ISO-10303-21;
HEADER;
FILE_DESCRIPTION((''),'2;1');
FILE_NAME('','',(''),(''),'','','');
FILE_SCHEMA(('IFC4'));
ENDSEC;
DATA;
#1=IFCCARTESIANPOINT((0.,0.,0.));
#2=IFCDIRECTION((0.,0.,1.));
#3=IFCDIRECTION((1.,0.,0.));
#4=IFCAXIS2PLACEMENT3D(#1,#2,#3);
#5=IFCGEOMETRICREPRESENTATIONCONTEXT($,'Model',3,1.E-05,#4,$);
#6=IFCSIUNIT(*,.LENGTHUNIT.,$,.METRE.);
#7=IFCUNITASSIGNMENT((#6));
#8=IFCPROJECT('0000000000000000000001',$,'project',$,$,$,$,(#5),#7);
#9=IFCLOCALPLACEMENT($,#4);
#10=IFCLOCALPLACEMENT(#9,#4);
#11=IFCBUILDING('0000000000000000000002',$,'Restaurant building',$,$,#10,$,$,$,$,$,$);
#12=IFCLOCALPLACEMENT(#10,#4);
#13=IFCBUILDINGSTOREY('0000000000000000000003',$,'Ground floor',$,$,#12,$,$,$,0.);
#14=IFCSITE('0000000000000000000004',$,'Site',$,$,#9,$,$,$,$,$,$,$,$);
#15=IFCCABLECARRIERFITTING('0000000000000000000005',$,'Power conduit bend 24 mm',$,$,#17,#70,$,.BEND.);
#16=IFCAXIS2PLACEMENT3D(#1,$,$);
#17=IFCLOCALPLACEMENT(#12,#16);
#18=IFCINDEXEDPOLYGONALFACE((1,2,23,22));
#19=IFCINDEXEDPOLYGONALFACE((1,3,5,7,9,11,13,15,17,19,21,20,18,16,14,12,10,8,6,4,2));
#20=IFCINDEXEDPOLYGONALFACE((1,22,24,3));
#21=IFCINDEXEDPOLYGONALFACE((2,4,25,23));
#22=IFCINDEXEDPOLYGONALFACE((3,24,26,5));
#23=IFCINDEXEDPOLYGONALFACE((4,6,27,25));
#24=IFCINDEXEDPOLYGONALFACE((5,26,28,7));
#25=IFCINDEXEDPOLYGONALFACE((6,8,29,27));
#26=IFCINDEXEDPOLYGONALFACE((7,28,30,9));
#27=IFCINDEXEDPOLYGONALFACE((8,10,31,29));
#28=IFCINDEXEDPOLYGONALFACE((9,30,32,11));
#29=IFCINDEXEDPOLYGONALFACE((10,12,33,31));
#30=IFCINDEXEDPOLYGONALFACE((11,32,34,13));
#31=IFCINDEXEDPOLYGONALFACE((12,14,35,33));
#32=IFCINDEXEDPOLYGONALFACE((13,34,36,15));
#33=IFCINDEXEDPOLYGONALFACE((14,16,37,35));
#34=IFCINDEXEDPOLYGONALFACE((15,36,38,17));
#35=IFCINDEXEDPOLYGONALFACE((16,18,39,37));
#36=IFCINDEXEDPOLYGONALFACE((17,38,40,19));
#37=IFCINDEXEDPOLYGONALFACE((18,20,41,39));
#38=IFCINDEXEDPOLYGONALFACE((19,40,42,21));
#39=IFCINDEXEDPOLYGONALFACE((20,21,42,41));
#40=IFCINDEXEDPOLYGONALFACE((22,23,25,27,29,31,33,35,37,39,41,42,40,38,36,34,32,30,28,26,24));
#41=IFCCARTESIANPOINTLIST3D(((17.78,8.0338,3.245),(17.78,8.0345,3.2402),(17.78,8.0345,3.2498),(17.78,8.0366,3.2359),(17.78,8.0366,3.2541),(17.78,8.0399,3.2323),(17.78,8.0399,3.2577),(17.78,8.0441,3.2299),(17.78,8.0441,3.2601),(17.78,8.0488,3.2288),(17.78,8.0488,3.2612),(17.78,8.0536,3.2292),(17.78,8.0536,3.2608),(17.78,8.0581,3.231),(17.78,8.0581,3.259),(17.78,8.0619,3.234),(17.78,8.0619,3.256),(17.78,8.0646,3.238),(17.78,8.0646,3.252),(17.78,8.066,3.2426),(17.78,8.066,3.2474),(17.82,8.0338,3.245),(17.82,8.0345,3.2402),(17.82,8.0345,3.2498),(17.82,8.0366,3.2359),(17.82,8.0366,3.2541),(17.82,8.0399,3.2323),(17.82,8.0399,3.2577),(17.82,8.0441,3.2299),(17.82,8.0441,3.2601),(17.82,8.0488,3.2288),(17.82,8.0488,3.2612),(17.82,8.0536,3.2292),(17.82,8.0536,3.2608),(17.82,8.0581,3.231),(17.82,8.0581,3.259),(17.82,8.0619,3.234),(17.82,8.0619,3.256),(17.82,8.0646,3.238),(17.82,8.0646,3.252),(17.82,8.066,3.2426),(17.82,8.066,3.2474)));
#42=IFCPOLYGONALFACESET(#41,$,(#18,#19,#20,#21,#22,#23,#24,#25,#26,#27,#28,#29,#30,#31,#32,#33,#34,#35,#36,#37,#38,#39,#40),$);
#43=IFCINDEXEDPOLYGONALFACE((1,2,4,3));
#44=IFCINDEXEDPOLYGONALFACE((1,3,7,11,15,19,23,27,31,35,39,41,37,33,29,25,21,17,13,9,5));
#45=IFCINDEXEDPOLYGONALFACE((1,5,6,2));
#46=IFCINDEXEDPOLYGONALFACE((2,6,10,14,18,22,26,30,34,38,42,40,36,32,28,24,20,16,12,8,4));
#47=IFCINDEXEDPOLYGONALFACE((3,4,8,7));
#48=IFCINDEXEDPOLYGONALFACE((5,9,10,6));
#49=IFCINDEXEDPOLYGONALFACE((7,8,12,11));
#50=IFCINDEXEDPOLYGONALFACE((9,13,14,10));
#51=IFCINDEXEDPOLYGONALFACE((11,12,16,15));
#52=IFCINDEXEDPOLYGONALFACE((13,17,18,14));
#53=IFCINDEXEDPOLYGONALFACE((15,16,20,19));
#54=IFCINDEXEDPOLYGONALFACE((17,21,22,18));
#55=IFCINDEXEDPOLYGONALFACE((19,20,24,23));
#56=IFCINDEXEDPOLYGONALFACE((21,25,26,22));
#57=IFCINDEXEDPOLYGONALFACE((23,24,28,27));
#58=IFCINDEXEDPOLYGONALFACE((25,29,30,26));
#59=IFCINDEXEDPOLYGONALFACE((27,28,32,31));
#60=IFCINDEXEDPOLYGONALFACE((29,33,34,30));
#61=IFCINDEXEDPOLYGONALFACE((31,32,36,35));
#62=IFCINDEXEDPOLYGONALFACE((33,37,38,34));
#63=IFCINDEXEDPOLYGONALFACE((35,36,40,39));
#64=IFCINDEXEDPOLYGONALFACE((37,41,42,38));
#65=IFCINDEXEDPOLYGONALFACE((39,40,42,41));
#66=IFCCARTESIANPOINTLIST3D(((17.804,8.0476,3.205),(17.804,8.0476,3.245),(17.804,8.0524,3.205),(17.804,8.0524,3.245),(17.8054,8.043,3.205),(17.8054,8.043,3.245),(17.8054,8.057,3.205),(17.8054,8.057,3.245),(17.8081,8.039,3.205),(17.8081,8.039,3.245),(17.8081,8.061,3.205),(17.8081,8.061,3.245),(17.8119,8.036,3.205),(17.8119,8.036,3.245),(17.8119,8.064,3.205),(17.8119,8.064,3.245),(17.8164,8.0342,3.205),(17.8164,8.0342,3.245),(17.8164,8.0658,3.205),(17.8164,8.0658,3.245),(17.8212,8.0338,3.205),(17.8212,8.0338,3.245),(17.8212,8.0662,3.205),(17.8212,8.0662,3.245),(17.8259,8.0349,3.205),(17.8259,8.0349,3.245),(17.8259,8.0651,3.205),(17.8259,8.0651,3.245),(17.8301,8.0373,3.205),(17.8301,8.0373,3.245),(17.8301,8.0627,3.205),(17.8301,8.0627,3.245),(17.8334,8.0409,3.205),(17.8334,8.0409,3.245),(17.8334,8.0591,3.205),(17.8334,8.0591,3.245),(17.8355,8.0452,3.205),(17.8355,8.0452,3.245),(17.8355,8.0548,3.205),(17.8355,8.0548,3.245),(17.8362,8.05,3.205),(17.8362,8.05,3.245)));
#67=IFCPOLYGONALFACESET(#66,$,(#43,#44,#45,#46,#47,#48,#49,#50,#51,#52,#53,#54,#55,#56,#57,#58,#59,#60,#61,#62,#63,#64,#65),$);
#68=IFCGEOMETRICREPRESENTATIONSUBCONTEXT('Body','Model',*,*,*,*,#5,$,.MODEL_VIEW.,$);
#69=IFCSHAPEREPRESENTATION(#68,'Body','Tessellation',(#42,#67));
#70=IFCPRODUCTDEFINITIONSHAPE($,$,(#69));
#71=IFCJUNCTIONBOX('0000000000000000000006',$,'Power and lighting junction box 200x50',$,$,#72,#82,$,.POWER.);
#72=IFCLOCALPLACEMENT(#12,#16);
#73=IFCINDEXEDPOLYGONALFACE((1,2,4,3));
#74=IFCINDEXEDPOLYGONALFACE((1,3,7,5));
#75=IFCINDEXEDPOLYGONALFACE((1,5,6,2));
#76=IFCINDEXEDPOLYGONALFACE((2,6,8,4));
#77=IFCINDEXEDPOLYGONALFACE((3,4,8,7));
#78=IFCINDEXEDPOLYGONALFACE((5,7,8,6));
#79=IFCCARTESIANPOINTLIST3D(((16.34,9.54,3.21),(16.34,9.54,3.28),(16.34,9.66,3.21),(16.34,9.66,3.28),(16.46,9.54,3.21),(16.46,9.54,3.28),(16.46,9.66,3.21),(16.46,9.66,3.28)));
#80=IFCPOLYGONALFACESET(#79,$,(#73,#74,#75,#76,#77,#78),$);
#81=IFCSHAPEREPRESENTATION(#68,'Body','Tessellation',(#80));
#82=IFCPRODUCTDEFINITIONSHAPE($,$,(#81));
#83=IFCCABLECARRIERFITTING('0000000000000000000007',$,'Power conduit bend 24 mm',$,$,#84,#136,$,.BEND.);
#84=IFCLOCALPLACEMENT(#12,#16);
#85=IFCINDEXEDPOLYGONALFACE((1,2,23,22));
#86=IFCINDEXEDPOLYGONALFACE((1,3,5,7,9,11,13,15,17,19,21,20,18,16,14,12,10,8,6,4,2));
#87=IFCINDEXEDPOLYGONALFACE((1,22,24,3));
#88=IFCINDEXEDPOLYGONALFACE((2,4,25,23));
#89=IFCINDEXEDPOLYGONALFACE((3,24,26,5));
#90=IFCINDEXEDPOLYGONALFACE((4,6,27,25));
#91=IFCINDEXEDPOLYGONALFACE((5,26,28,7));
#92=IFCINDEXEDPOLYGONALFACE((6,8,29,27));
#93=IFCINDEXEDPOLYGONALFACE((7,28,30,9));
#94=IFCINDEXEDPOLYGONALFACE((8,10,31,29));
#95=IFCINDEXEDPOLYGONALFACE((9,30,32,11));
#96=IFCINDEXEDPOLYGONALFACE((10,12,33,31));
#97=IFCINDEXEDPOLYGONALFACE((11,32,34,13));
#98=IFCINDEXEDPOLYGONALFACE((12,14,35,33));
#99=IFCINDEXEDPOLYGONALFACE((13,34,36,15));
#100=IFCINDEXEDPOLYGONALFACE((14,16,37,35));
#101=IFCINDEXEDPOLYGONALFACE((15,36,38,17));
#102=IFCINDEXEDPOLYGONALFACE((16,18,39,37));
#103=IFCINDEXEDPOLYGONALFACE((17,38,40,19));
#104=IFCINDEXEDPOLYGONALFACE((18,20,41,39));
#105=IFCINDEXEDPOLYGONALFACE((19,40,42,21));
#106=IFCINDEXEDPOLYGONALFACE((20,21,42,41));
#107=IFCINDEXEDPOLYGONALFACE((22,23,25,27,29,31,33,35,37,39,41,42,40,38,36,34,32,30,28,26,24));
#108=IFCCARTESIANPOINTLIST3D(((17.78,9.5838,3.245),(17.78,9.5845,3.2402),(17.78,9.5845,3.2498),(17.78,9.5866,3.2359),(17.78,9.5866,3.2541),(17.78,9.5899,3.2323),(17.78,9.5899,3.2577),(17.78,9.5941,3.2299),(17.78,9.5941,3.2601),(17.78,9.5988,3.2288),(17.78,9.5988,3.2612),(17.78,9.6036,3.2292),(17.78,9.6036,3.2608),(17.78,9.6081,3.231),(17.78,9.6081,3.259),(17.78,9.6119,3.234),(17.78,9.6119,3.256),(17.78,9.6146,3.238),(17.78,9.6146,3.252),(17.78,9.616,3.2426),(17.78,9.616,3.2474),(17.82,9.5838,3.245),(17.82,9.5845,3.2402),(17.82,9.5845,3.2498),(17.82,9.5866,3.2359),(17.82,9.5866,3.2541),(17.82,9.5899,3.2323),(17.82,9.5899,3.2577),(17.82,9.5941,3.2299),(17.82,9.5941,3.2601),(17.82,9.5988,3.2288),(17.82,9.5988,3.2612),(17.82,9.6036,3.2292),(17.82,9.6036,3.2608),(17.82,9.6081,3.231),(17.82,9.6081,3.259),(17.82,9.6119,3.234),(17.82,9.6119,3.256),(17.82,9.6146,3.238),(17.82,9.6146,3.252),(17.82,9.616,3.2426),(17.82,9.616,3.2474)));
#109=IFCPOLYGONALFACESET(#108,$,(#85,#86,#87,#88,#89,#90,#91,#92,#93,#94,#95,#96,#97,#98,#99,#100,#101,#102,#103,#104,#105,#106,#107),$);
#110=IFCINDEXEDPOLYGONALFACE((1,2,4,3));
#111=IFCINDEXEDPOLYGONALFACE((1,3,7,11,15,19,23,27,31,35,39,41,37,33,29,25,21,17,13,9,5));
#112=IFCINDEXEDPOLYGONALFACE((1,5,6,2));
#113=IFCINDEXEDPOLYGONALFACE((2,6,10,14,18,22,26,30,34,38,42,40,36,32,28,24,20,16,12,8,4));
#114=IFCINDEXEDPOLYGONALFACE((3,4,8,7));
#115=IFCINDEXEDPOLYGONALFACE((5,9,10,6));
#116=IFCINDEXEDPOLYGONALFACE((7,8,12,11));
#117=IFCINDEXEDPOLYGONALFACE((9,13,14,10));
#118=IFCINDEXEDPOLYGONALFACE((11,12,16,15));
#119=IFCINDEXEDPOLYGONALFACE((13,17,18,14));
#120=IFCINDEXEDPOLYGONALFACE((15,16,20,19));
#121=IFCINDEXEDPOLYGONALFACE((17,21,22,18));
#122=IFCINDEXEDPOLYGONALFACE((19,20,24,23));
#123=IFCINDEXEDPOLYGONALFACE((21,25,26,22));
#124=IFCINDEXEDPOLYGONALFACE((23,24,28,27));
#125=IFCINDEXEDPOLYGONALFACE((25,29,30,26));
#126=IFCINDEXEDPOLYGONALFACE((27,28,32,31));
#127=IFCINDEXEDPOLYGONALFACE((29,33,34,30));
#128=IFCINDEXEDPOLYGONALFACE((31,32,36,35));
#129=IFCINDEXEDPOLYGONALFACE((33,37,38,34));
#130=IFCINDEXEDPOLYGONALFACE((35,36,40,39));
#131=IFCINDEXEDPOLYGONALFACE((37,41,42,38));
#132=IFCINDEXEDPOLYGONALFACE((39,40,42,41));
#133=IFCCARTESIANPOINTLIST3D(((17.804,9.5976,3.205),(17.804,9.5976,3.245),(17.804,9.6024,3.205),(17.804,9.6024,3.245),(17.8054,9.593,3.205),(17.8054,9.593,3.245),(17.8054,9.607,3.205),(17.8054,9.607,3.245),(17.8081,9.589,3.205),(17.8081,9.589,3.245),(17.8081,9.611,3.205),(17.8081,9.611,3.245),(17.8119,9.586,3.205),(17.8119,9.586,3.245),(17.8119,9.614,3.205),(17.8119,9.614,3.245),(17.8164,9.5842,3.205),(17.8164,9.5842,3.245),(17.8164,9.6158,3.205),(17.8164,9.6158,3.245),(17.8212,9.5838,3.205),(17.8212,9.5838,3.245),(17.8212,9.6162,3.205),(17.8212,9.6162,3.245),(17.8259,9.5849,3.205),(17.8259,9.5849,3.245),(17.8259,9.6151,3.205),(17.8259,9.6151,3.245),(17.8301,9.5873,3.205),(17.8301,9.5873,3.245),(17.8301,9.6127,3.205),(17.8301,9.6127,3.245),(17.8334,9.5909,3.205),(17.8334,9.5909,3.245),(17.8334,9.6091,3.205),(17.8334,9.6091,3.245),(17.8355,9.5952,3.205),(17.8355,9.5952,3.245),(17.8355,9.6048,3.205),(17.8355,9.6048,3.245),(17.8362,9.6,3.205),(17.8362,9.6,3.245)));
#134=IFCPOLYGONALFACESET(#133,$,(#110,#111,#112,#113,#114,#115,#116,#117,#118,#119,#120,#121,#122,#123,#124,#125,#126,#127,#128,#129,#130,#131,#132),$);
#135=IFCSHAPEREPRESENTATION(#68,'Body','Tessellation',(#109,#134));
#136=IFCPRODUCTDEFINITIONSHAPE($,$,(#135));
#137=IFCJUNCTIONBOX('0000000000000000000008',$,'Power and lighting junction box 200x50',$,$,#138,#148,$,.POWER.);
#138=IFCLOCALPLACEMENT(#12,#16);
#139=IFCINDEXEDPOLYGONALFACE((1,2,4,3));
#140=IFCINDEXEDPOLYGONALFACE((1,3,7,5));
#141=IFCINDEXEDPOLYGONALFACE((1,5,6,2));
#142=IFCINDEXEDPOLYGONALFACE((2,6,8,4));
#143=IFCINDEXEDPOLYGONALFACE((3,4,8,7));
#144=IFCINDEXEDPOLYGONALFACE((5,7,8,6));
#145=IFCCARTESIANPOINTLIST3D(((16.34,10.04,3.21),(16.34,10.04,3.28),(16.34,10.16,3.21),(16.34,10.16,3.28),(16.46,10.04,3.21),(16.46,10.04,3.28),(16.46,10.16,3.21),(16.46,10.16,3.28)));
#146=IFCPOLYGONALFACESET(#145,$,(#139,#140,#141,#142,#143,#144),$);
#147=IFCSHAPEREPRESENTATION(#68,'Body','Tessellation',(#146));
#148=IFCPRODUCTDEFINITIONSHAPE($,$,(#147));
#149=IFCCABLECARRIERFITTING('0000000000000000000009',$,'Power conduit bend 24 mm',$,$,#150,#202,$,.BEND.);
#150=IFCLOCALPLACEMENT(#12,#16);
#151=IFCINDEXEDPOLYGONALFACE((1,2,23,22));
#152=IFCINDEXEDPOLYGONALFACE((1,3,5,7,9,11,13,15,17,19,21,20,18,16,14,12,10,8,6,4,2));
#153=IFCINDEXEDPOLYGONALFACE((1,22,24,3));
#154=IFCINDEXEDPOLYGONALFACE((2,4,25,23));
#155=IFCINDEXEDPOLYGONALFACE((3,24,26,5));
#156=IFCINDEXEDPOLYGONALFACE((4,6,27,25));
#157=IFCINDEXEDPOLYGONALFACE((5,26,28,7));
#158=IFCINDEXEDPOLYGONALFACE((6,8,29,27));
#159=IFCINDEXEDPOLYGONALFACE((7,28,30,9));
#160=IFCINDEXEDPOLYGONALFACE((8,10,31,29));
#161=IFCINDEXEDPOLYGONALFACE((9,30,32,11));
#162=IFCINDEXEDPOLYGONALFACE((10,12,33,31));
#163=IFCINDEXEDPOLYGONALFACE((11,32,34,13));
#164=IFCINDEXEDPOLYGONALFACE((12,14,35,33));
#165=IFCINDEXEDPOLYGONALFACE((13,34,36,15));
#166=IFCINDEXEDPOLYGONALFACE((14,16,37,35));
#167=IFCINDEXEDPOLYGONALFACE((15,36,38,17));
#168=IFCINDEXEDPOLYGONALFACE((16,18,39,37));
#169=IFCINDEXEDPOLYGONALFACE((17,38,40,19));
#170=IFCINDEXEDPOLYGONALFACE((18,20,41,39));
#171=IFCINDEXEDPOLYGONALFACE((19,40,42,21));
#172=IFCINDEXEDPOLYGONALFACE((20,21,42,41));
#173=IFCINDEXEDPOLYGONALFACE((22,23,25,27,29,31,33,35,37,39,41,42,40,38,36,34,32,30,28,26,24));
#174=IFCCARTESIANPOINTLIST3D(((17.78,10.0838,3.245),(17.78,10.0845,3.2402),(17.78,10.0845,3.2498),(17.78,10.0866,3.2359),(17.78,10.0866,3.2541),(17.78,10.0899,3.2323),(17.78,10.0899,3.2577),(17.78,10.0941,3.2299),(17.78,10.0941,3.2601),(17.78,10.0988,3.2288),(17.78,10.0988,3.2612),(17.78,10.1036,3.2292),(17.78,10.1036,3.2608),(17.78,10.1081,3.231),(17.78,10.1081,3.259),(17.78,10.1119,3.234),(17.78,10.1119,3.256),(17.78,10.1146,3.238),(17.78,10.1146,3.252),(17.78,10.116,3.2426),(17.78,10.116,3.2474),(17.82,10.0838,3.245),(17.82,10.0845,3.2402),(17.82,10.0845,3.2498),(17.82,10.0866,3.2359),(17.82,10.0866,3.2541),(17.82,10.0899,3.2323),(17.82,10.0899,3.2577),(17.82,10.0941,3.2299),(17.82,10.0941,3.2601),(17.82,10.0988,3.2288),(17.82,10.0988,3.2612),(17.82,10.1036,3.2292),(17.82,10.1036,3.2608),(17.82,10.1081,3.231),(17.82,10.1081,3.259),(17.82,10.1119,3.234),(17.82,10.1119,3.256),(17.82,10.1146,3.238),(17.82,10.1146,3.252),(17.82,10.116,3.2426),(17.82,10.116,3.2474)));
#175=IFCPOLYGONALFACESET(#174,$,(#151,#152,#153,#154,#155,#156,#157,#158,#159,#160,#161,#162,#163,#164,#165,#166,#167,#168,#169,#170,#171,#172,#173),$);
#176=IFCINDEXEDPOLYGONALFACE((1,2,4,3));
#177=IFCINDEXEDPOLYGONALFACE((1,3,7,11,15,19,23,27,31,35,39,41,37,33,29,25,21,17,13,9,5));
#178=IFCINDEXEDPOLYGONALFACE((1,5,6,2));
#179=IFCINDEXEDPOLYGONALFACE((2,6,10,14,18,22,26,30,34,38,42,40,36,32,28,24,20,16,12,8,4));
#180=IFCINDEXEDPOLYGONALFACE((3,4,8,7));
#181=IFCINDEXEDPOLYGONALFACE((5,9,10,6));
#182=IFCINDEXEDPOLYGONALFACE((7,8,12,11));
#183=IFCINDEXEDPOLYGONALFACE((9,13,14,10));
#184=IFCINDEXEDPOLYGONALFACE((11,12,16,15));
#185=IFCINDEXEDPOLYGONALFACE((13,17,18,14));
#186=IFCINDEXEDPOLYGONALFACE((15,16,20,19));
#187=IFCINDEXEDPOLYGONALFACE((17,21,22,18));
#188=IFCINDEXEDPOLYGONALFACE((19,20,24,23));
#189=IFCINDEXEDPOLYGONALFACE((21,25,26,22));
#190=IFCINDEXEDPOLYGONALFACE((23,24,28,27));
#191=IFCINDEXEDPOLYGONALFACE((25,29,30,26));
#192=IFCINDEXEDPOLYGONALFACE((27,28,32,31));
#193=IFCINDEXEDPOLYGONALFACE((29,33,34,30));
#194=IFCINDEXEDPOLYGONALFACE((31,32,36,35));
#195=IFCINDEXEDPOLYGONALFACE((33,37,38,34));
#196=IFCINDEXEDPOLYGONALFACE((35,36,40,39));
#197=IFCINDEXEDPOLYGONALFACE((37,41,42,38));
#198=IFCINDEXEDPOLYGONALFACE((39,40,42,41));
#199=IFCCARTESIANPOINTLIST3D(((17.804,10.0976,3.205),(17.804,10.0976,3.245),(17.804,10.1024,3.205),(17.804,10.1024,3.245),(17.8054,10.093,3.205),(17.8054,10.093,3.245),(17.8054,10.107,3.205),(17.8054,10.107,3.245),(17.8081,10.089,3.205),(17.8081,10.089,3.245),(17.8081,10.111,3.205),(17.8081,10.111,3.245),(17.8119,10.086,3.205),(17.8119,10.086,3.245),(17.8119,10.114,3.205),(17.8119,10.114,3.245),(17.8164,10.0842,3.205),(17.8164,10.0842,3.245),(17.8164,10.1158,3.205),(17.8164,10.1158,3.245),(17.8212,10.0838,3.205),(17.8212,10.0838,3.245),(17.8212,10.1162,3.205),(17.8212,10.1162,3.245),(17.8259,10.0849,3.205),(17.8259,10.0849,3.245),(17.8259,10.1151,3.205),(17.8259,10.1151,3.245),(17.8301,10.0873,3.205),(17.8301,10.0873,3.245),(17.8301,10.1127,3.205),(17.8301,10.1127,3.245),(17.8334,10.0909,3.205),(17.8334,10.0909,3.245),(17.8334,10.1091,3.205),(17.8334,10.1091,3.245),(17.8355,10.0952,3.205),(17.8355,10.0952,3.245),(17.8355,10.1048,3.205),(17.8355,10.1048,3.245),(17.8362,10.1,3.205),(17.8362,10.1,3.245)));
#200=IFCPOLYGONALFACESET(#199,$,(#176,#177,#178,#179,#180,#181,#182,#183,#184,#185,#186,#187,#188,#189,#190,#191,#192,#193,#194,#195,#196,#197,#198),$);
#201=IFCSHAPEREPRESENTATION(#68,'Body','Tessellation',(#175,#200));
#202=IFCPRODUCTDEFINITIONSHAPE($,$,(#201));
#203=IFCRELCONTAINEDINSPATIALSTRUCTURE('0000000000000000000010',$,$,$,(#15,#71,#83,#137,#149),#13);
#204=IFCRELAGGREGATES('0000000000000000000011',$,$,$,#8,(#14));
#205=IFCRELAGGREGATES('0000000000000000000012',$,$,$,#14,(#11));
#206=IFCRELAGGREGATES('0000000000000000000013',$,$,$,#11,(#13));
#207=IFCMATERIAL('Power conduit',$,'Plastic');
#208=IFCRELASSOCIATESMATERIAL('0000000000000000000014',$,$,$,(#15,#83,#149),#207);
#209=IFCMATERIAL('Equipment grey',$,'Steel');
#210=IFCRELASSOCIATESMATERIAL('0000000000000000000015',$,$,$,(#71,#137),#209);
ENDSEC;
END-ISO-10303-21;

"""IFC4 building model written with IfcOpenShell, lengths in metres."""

from ifc_helpers import new_model, si_unit, frame, origin_with_axes, origin_2d, place, context, subcontext, project, spatial, rectangle, circle, extrude, material, element, save


model = new_model("IFC4")

# Units and contexts
model_context = context("Model", 3, precision=1e-05, world=origin_with_axes())
body_context = subcontext(model_context, "Body", "Model", "MODEL_VIEW")
ifc_project = project(units=[si_unit("LENGTHUNIT", "METRE")], contexts=[model_context])

# Site, building, storey
site_placement = place(None, origin_with_axes())
site = spatial("IfcSite", under=ifc_project, at=site_placement, Name="Site")
building_placement = place(site_placement, origin_with_axes())
building = spatial("IfcBuilding", under=site, at=building_placement, Name="Restaurant building")
storey_placement = place(building_placement, origin_with_axes())
storey = spatial("IfcBuildingStorey", under=building, at=storey_placement, Name="Ground floor", Elevation=0.0)

# Shared definitions
ifc_material_1 = material(Name="Power conduit", Category="Plastic")

# Shared definitions
ifc_material_2 = material(Name="Equipment grey", Category="Steel")

# Cable carrier fitting
cable_carrier_fitting_1_placement = place(storey_placement, frame((17.82, 8.05, 3.245)))
element("IfcCableCarrierFitting", 1, at=cable_carrier_fitting_1_placement, inside=storey, material=ifc_material_1, Name="Power conduit bend 24 mm", PredefinedType="BEND", context=body_context, shape_type="SweptSolid", body=[
    extrude(circle(Radius=0.0162, at=origin_2d()), frame((0.0, 0.0, 0.0), z_axis=(-1.0, 0.0, 0.0), x_axis=(0.0, -1.0, 0.0)), (0.0, 0.0, 1.0), 0.04),
    extrude(circle(Radius=0.0162, at=origin_2d()), frame((0.0, 0.0, 0.0), z_axis=(0.0, 0.0, -1.0), x_axis=(1.0, 0.0, 0.0)), (0.0, 0.0, 1.0), 0.04),
])

# Junction box
junction_box_1_placement = place(storey_placement, frame((16.4, 9.6, 3.245)))
element("IfcJunctionBox", 2, at=junction_box_1_placement, inside=storey, material=ifc_material_2, Name="Power and lighting junction box 200x50", PredefinedType="POWER", context=body_context, shape_type="SweptSolid", body=[
    extrude(rectangle(XDim=0.12, YDim=0.12, at=origin_2d()), frame((0.0, 0.0, -0.035)), (0.0, 0.0, 1.0), 0.07),
])

# Cable carrier fitting
cable_carrier_fitting_2_placement = place(storey_placement, frame((17.82, 9.6, 3.245)))
element("IfcCableCarrierFitting", 3, at=cable_carrier_fitting_2_placement, inside=storey, material=ifc_material_1, Name="Power conduit bend 24 mm", PredefinedType="BEND", context=body_context, shape_type="SweptSolid", body=[
    extrude(circle(Radius=0.0162, at=origin_2d()), frame((0.0, 0.0, 0.0), z_axis=(-1.0, 0.0, 0.0), x_axis=(0.0, -1.0, 0.0)), (0.0, 0.0, 1.0), 0.04),
    extrude(circle(Radius=0.0162, at=origin_2d()), frame((0.0, 0.0, 0.0), z_axis=(0.0, 0.0, -1.0), x_axis=(1.0, 0.0, 0.0)), (0.0, 0.0, 1.0), 0.04),
])

# Junction box
junction_box_2_placement = place(storey_placement, frame((16.4, 10.1, 3.245)))
element("IfcJunctionBox", 4, at=junction_box_2_placement, inside=storey, material=ifc_material_2, Name="Power and lighting junction box 200x50", PredefinedType="POWER", context=body_context, shape_type="SweptSolid", body=[
    extrude(rectangle(XDim=0.12, YDim=0.12, at=origin_2d()), frame((0.0, 0.0, -0.035)), (0.0, 0.0, 1.0), 0.07),
])

# Cable carrier fitting
cable_carrier_fitting_3_placement = place(storey_placement, frame((17.82, 10.1, 3.245)))
element("IfcCableCarrierFitting", 5, at=cable_carrier_fitting_3_placement, inside=storey, material=ifc_material_1, Name="Power conduit bend 24 mm", PredefinedType="BEND", context=body_context, shape_type="SweptSolid", body=[
    extrude(circle(Radius=0.0162, at=origin_2d()), frame((0.0, 0.0, 0.0), z_axis=(-1.0, 0.0, 0.0), x_axis=(0.0, -1.0, 0.0)), (0.0, 0.0, 1.0), 0.04),
    extrude(circle(Radius=0.0162, at=origin_2d()), frame((0.0, 0.0, 0.0), z_axis=(0.0, 0.0, -1.0), x_axis=(1.0, 0.0, 0.0)), (0.0, 0.0, 1.0), 0.04),
])

save(model, "model.ifc")
